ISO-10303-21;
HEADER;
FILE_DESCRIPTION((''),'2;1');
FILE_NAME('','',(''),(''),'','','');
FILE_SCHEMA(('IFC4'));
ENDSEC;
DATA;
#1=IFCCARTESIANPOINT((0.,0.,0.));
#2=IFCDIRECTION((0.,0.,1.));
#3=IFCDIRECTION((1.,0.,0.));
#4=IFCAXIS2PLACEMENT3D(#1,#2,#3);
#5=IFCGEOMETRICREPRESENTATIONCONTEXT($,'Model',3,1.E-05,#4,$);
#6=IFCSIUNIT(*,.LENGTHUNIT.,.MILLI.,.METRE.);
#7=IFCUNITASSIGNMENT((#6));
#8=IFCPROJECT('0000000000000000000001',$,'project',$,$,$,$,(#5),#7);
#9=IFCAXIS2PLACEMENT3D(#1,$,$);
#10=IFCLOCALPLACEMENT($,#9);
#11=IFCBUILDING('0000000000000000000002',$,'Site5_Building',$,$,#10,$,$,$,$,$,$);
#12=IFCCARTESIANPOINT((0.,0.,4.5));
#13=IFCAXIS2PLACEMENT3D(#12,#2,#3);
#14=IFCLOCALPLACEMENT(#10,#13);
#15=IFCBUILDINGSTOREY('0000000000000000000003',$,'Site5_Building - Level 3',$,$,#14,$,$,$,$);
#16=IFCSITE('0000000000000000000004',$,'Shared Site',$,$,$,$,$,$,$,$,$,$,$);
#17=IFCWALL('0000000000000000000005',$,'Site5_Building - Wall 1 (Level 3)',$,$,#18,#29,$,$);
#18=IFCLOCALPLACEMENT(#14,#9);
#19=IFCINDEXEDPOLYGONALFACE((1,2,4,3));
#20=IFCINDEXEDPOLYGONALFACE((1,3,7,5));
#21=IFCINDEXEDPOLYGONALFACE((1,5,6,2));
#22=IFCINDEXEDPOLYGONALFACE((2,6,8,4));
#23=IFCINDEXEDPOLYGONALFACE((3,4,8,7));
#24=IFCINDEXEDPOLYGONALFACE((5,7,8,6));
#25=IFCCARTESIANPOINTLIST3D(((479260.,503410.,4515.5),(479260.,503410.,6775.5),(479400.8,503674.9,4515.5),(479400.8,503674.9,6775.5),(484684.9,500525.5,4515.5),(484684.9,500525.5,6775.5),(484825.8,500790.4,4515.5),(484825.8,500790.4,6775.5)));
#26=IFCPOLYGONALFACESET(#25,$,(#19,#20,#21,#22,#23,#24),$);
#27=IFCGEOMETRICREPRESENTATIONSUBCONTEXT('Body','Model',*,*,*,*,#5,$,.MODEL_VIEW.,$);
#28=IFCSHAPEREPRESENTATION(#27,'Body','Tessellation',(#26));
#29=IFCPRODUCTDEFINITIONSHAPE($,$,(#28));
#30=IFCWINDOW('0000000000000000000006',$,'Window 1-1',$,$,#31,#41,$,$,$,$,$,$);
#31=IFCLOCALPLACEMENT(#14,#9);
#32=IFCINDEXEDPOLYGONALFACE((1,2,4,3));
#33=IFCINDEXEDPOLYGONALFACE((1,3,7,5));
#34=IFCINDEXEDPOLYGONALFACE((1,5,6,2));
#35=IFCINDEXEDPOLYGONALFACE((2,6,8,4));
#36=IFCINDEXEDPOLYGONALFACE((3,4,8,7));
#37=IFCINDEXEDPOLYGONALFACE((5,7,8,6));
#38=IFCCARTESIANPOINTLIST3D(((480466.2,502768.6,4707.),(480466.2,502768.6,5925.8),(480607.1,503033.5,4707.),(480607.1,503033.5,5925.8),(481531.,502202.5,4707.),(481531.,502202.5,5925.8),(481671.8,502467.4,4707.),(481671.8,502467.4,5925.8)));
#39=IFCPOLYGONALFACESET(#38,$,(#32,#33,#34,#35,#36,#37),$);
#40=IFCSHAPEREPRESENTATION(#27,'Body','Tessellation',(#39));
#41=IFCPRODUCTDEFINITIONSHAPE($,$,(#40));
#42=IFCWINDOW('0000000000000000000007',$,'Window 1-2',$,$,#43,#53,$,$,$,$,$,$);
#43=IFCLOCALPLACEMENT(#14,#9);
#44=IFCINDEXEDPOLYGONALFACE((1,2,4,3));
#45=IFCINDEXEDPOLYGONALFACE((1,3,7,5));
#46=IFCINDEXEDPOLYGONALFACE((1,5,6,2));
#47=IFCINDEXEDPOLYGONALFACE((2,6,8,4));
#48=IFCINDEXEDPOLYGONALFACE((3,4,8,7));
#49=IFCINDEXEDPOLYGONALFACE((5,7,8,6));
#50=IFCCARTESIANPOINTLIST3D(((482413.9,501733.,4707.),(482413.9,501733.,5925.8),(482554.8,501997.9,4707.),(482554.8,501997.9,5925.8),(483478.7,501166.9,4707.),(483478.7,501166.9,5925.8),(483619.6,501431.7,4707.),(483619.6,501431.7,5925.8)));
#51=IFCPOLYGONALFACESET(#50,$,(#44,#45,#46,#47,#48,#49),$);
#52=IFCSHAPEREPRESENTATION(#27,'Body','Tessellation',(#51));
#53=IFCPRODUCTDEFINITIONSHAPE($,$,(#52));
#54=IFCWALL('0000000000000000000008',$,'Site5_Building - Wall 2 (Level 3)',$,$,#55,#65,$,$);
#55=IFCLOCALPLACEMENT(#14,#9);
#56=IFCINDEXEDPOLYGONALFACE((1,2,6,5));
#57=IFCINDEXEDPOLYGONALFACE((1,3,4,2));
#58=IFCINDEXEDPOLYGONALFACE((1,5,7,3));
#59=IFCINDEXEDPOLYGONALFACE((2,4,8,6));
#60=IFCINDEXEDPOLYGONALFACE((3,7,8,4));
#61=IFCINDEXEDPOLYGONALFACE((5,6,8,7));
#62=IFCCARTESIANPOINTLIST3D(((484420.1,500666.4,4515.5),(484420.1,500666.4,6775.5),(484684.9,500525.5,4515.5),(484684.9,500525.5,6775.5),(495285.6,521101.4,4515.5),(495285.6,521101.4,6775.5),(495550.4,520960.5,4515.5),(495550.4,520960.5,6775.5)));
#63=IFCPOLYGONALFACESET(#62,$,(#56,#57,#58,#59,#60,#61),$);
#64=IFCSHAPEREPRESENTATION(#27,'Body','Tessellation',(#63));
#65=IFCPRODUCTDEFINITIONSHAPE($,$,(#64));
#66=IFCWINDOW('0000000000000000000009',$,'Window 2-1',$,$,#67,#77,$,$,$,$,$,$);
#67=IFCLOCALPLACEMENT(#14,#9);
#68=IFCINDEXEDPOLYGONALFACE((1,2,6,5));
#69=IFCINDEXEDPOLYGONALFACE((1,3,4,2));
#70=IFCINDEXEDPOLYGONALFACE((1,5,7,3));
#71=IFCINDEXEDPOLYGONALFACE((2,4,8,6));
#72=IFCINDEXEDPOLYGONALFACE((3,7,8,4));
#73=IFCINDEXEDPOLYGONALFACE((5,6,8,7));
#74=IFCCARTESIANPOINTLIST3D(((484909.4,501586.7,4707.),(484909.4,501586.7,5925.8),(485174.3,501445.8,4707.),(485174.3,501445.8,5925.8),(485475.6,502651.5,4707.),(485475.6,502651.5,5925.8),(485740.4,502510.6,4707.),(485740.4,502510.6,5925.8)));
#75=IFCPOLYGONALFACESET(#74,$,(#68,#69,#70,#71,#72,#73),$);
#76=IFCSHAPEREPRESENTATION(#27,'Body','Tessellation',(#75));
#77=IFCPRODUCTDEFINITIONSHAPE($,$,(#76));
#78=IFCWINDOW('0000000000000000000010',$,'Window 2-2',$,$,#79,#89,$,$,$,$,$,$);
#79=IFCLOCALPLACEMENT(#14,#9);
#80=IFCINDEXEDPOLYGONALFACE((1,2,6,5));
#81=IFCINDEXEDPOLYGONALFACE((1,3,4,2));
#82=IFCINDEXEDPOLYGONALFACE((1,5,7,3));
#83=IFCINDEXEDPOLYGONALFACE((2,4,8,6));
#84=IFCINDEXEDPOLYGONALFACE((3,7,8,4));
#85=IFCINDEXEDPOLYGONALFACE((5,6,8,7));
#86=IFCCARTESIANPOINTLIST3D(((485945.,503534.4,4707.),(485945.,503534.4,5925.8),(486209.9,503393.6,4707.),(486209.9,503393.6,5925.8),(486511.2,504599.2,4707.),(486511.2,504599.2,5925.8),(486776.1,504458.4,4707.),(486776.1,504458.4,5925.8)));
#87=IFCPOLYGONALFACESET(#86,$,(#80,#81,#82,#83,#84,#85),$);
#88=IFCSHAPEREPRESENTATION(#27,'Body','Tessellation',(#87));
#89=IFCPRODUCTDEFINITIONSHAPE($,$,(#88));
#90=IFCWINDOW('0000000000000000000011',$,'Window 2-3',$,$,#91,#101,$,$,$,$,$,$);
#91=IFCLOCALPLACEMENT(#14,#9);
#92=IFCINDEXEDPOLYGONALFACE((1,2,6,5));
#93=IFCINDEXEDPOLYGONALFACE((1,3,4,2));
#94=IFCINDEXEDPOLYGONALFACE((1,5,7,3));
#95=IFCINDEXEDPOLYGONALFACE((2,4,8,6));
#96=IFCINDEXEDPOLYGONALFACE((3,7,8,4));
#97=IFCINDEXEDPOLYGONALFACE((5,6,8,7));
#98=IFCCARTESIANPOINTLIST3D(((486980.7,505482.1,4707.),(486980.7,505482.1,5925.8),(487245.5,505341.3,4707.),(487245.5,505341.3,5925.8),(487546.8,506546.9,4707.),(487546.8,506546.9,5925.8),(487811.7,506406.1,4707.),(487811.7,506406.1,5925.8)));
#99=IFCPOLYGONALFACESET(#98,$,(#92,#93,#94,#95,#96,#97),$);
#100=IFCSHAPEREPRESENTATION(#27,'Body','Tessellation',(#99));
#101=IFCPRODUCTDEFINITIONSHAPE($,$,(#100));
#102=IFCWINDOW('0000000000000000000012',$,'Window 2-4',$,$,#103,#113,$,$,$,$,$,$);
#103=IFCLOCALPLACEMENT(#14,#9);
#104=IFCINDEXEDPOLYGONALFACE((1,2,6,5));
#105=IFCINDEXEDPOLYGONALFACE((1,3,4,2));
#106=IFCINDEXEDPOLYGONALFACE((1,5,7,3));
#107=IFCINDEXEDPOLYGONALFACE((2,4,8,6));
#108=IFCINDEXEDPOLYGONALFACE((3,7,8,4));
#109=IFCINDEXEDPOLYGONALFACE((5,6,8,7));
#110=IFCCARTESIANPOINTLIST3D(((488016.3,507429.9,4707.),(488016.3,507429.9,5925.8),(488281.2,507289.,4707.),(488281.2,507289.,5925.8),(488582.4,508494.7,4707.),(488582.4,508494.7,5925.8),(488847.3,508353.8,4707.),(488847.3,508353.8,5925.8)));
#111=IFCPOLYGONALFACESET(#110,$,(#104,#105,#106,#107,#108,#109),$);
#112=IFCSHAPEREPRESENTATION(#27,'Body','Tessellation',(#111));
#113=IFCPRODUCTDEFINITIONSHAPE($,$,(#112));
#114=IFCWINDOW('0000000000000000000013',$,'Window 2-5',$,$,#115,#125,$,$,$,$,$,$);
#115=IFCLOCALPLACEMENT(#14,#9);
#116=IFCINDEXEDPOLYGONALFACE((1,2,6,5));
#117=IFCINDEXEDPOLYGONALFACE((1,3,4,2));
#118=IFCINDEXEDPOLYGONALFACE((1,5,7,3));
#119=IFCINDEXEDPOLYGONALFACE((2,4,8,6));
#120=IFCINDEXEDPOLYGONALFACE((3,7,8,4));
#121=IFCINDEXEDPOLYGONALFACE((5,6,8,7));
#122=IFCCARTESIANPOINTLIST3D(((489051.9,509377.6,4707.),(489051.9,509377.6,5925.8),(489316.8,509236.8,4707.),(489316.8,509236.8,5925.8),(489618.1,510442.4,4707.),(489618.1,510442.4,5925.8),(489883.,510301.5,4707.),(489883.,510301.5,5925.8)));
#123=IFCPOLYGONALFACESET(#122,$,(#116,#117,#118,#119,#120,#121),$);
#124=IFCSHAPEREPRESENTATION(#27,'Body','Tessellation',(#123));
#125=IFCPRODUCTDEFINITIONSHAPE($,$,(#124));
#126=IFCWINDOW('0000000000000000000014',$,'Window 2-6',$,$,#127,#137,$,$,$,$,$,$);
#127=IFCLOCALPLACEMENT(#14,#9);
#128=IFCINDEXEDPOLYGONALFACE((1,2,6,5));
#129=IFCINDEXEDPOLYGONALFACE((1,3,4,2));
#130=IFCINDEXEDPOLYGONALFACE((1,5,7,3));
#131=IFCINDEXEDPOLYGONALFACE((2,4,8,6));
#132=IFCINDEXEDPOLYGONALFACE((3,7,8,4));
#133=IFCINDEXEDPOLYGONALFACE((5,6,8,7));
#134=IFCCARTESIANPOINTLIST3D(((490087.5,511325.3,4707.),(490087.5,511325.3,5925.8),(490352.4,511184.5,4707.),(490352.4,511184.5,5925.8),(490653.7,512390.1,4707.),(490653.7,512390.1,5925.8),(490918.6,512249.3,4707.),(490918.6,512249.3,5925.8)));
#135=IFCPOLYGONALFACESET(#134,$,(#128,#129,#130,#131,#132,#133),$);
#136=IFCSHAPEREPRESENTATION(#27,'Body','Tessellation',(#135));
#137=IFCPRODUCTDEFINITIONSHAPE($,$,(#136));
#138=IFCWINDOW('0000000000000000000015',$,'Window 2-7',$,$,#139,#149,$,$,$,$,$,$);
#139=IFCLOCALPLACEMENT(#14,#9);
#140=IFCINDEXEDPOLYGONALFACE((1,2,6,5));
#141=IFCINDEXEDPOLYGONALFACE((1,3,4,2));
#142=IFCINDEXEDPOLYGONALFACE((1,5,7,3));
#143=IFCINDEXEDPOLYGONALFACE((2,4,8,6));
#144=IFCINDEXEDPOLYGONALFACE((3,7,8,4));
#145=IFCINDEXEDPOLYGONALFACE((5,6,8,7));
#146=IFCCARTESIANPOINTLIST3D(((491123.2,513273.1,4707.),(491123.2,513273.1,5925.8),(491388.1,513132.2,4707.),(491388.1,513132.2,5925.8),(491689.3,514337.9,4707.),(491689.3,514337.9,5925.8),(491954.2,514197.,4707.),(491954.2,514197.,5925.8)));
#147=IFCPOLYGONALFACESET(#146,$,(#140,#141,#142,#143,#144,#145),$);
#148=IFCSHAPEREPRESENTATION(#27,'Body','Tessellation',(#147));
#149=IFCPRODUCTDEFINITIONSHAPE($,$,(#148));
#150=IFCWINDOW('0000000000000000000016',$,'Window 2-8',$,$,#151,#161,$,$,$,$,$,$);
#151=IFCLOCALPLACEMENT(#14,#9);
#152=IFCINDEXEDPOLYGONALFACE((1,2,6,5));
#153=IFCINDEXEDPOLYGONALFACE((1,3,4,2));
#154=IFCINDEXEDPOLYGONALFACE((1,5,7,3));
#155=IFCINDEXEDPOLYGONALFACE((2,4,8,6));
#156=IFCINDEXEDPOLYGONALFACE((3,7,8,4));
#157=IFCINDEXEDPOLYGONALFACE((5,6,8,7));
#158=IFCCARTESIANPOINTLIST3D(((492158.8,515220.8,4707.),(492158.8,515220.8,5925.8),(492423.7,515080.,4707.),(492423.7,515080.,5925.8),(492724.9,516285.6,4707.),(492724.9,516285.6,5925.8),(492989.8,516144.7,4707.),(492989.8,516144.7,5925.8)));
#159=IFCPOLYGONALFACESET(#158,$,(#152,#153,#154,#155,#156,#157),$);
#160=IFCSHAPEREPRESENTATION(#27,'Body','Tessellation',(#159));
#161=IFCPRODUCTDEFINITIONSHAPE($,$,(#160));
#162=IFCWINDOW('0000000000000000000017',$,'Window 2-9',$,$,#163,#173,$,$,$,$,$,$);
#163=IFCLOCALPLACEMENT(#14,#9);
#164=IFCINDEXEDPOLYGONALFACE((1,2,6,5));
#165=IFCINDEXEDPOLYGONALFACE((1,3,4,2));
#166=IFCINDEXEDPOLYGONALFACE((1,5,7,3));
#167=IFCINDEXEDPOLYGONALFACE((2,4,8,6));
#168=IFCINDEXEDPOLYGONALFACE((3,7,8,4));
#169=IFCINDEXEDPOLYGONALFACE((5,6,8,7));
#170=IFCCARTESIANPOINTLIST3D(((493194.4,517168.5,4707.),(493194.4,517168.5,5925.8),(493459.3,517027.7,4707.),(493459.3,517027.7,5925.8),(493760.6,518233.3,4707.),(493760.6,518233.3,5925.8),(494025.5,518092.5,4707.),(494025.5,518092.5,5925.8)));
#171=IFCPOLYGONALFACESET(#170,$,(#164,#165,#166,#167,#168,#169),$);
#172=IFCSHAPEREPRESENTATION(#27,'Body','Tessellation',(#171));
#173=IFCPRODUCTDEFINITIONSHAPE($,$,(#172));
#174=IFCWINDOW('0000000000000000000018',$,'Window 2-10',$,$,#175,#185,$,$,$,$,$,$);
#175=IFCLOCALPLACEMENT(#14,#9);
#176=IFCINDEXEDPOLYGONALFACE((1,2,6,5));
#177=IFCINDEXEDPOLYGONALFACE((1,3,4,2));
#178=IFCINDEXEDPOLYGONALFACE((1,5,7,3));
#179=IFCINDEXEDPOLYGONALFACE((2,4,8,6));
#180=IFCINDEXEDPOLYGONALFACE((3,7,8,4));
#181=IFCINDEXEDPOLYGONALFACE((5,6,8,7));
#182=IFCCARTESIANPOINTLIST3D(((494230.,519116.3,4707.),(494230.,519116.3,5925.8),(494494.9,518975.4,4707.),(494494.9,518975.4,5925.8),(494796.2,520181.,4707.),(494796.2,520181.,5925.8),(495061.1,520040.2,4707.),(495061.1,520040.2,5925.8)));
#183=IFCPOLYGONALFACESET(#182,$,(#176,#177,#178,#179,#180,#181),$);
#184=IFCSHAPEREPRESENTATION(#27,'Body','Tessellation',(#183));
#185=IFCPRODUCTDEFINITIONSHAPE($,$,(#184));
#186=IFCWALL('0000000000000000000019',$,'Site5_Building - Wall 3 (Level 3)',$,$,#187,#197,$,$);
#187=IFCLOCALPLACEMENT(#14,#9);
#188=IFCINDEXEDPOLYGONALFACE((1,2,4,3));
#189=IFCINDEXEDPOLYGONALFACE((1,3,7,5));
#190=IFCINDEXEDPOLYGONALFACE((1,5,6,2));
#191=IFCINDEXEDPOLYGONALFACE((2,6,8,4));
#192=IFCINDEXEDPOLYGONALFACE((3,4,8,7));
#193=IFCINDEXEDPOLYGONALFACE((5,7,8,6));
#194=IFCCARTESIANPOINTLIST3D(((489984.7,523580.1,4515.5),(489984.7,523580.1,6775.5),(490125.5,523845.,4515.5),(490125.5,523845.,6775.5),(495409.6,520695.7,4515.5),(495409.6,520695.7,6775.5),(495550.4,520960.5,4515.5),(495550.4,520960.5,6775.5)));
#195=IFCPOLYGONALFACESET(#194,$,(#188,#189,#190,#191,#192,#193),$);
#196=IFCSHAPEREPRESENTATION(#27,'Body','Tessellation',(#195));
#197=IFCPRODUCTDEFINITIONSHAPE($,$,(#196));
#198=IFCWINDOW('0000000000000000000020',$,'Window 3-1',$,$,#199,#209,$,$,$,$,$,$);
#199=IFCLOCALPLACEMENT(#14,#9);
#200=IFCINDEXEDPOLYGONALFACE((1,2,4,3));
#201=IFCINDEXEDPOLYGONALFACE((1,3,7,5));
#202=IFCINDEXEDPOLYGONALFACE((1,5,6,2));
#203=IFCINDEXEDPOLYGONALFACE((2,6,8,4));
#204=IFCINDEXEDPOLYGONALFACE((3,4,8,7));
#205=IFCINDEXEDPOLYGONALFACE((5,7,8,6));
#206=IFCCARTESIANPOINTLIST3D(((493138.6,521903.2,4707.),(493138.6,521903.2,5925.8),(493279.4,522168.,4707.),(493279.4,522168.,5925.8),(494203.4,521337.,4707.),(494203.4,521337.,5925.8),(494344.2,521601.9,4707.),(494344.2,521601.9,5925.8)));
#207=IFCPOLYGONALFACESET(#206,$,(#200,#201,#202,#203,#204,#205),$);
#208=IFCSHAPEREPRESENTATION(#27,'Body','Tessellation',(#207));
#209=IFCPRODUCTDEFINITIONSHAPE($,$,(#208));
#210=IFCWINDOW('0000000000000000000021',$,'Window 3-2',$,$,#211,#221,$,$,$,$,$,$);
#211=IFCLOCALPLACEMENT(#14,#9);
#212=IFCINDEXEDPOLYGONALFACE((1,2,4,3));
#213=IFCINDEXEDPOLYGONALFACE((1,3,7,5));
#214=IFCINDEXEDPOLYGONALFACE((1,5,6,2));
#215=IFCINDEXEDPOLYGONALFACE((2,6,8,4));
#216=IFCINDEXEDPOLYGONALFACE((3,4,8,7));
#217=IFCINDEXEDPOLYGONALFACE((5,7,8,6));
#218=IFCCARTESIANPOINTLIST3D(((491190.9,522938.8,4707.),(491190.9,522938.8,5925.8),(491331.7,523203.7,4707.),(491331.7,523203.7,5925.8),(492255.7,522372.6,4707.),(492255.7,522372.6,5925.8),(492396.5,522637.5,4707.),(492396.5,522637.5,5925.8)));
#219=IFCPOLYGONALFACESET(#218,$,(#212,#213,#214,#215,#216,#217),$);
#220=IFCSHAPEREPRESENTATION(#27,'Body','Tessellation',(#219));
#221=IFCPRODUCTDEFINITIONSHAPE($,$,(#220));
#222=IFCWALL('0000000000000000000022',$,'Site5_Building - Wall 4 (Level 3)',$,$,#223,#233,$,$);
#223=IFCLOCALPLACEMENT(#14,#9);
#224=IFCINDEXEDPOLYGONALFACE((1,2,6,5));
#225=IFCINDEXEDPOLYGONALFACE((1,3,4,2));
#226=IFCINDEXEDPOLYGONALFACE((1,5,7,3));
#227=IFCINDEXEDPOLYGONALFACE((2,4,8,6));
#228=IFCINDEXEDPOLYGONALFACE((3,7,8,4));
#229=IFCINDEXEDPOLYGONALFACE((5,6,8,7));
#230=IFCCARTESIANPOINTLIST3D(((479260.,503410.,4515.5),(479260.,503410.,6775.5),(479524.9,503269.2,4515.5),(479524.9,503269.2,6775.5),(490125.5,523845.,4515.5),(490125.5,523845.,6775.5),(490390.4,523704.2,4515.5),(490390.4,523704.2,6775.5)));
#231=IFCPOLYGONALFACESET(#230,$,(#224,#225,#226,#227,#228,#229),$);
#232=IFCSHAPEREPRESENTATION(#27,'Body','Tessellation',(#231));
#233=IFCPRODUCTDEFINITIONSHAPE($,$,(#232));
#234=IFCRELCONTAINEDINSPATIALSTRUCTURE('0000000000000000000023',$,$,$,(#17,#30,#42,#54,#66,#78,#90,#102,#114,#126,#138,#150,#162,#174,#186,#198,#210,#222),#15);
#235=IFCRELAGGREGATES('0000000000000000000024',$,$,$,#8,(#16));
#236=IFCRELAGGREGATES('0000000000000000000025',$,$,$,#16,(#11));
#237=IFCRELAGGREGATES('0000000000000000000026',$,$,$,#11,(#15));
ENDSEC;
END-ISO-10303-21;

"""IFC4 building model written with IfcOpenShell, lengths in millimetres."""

from ifc_helpers import new_model, si_unit, frame, origin, origin_with_axes, place, context, subcontext, project, spatial, indexed_curve, outline, extrude, element, save


model = new_model("IFC4")

# Units and contexts
model_context = context("Model", 3, precision=1e-05, world=origin_with_axes())
body_context = subcontext(model_context, "Body", "Model", "MODEL_VIEW")
ifc_project = project(units=[si_unit("LENGTHUNIT", "METRE", prefix="MILLI")], contexts=[model_context])

# Site, building, storey
site = spatial("IfcSite", under=ifc_project, Name="Shared Site")
building_placement = place(None, origin())
building = spatial("IfcBuilding", under=site, at=building_placement, Name="Site5_Building")
storey_placement = place(building_placement, frame((0.0, 0.0, 4.5), z_axis=(0.0, 0.0, 1.0), x_axis=(1.0, 0.0, 0.0)))
storey = spatial("IfcBuildingStorey", under=building, at=storey_placement, Name="Site5_Building - Level 3")

# Wall
wall_1_placement = place(storey_placement, frame((479260.0, 503410.0, 4515.5), z_axis=(0.0, 0.0, 1.0), x_axis=(0.882948, -0.469472, 0.0)))
element("IfcWall", 1, at=wall_1_placement, inside=storey, Name="Site5_Building - Wall 1 (Level 3)", context=body_context, shape_type="SweptSolid", body=[
    extrude(outline(indexed_curve([(0.0, 0.0), (0.0, 300.0), (6144.1, 300.0), (6144.1, 0.0), (0.0, 0.0)], self_intersect=False)), origin_with_axes(), (0.0, 0.0, 1.0), 2260.0),
])

# Windows
for number, where, z_axis, x_axis, name in (
    (2, (480466.2, 502768.6, 4707.0), (0.0, 0.0, 1.0), (0.882948, -0.469472, 0.0), "Window 1-1"),
    (3, (482413.9, 501733.0, 4707.0), (0.0, 0.0, 1.0), (0.882948, -0.469472, 0.0), "Window 1-2"),
):
    element("IfcWindow", number, at=place(storey_placement, frame(where, z_axis=z_axis, x_axis=x_axis)), inside=storey, Name=name, context=body_context, shape_type="SweptSolid", body=[
        extrude(outline(indexed_curve([(0.0, 0.0), (0.0, 300.0), (1205.9, 300.0), (1205.9, 0.0), (0.0, 0.0)], self_intersect=False)), origin_with_axes(), (0.0, 0.0, 1.0), 1218.8),
    ])

# Wall
wall_2_placement = place(storey_placement, frame((484684.9, 500525.5, 4515.5), z_axis=(0.0, 0.0, 1.0), x_axis=(0.469472, 0.882948, 0.0)))
element("IfcWall", 4, at=wall_2_placement, inside=storey, Name="Site5_Building - Wall 2 (Level 3)", context=body_context, shape_type="SweptSolid", body=[
    extrude(outline(indexed_curve([(0.0, 0.0), (0.0, 300.0), (23144.1, 300.0), (23144.1, 0.0), (0.0, 0.0)], self_intersect=False)), origin_with_axes(), (0.0, 0.0, 1.0), 2260.0),
])

# Windows
for number, where, z_axis, x_axis, name in (
    (5, (485174.3, 501445.8, 4707.0), (0.0, 0.0, 1.0), (0.469472, 0.882948, 0.0), "Window 2-1"),
    (6, (486209.9, 503393.6, 4707.0), (0.0, 0.0, 1.0), (0.469472, 0.882948, 0.0), "Window 2-2"),
    (7, (487245.5, 505341.3, 4707.0), (0.0, 0.0, 1.0), (0.469472, 0.882948, 0.0), "Window 2-3"),
    (8, (488281.2, 507289.0, 4707.0), (0.0, 0.0, 1.0), (0.469472, 0.882948, 0.0), "Window 2-4"),
    (9, (489316.8, 509236.8, 4707.0), (0.0, 0.0, 1.0), (0.469472, 0.882948, 0.0), "Window 2-5"),
    (10, (490352.4, 511184.5, 4707.0), (0.0, 0.0, 1.0), (0.469472, 0.882948, 0.0), "Window 2-6"),
    (11, (491388.1, 513132.2, 4707.0), (0.0, 0.0, 1.0), (0.469472, 0.882948, 0.0), "Window 2-7"),
    (12, (492423.7, 515080.0, 4707.0), (0.0, 0.0, 1.0), (0.469472, 0.882948, 0.0), "Window 2-8"),
    (13, (493459.3, 517027.7, 4707.0), (0.0, 0.0, 1.0), (0.469472, 0.882948, 0.0), "Window 2-9"),
    (14, (494494.9, 518975.4, 4707.0), (0.0, 0.0, 1.0), (0.469472, 0.882948, 0.0), "Window 2-10"),
):
    element("IfcWindow", number, at=place(storey_placement, frame(where, z_axis=z_axis, x_axis=x_axis)), inside=storey, Name=name, context=body_context, shape_type="SweptSolid", body=[
        extrude(outline(indexed_curve([(0.0, 0.0), (0.0, 300.0), (1205.9, 300.0), (1205.9, 0.0), (0.0, 0.0)], self_intersect=False)), origin_with_axes(), (0.0, 0.0, 1.0), 1218.8),
    ])

# Wall
wall_3_placement = place(storey_placement, frame((495550.4, 520960.5, 4515.5), z_axis=(0.0, 0.0, 1.0), x_axis=(-0.882948, 0.469472, 0.0)))
element("IfcWall", 15, at=wall_3_placement, inside=storey, Name="Site5_Building - Wall 3 (Level 3)", context=body_context, shape_type="SweptSolid", body=[
    extrude(outline(indexed_curve([(0.0, 0.0), (0.0, 300.0), (6144.1, 300.0), (6144.1, 0.0), (0.0, 0.0)], self_intersect=False)), origin_with_axes(), (0.0, 0.0, 1.0), 2260.0),
])

# Windows
for number, where, z_axis, x_axis, name in (
    (16, (494344.2, 521601.9, 4707.0), (0.0, 0.0, 1.0), (-0.882948, 0.469472, 0.0), "Window 3-1"),
    (17, (492396.5, 522637.5, 4707.0), (0.0, 0.0, 1.0), (-0.882948, 0.469472, 0.0), "Window 3-2"),
):
    element("IfcWindow", number, at=place(storey_placement, frame(where, z_axis=z_axis, x_axis=x_axis)), inside=storey, Name=name, context=body_context, shape_type="SweptSolid", body=[
        extrude(outline(indexed_curve([(0.0, 0.0), (0.0, 300.0), (1205.9, 300.0), (1205.9, 0.0), (0.0, 0.0)], self_intersect=False)), origin_with_axes(), (0.0, 0.0, 1.0), 1218.8),
    ])

# Wall
wall_4_placement = place(storey_placement, frame((490125.5, 523845.0, 4515.5), z_axis=(0.0, 0.0, 1.0), x_axis=(-0.469472, -0.882948, 0.0)))
element("IfcWall", 18, at=wall_4_placement, inside=storey, Name="Site5_Building - Wall 4 (Level 3)", context=body_context, shape_type="SweptSolid", body=[
    extrude(outline(indexed_curve([(0.0, 0.0), (0.0, 300.0), (23144.1, 300.0), (23144.1, 0.0), (0.0, 0.0)], self_intersect=False)), origin_with_axes(), (0.0, 0.0, 1.0), 2260.0),
])

save(model, "model.ifc")
